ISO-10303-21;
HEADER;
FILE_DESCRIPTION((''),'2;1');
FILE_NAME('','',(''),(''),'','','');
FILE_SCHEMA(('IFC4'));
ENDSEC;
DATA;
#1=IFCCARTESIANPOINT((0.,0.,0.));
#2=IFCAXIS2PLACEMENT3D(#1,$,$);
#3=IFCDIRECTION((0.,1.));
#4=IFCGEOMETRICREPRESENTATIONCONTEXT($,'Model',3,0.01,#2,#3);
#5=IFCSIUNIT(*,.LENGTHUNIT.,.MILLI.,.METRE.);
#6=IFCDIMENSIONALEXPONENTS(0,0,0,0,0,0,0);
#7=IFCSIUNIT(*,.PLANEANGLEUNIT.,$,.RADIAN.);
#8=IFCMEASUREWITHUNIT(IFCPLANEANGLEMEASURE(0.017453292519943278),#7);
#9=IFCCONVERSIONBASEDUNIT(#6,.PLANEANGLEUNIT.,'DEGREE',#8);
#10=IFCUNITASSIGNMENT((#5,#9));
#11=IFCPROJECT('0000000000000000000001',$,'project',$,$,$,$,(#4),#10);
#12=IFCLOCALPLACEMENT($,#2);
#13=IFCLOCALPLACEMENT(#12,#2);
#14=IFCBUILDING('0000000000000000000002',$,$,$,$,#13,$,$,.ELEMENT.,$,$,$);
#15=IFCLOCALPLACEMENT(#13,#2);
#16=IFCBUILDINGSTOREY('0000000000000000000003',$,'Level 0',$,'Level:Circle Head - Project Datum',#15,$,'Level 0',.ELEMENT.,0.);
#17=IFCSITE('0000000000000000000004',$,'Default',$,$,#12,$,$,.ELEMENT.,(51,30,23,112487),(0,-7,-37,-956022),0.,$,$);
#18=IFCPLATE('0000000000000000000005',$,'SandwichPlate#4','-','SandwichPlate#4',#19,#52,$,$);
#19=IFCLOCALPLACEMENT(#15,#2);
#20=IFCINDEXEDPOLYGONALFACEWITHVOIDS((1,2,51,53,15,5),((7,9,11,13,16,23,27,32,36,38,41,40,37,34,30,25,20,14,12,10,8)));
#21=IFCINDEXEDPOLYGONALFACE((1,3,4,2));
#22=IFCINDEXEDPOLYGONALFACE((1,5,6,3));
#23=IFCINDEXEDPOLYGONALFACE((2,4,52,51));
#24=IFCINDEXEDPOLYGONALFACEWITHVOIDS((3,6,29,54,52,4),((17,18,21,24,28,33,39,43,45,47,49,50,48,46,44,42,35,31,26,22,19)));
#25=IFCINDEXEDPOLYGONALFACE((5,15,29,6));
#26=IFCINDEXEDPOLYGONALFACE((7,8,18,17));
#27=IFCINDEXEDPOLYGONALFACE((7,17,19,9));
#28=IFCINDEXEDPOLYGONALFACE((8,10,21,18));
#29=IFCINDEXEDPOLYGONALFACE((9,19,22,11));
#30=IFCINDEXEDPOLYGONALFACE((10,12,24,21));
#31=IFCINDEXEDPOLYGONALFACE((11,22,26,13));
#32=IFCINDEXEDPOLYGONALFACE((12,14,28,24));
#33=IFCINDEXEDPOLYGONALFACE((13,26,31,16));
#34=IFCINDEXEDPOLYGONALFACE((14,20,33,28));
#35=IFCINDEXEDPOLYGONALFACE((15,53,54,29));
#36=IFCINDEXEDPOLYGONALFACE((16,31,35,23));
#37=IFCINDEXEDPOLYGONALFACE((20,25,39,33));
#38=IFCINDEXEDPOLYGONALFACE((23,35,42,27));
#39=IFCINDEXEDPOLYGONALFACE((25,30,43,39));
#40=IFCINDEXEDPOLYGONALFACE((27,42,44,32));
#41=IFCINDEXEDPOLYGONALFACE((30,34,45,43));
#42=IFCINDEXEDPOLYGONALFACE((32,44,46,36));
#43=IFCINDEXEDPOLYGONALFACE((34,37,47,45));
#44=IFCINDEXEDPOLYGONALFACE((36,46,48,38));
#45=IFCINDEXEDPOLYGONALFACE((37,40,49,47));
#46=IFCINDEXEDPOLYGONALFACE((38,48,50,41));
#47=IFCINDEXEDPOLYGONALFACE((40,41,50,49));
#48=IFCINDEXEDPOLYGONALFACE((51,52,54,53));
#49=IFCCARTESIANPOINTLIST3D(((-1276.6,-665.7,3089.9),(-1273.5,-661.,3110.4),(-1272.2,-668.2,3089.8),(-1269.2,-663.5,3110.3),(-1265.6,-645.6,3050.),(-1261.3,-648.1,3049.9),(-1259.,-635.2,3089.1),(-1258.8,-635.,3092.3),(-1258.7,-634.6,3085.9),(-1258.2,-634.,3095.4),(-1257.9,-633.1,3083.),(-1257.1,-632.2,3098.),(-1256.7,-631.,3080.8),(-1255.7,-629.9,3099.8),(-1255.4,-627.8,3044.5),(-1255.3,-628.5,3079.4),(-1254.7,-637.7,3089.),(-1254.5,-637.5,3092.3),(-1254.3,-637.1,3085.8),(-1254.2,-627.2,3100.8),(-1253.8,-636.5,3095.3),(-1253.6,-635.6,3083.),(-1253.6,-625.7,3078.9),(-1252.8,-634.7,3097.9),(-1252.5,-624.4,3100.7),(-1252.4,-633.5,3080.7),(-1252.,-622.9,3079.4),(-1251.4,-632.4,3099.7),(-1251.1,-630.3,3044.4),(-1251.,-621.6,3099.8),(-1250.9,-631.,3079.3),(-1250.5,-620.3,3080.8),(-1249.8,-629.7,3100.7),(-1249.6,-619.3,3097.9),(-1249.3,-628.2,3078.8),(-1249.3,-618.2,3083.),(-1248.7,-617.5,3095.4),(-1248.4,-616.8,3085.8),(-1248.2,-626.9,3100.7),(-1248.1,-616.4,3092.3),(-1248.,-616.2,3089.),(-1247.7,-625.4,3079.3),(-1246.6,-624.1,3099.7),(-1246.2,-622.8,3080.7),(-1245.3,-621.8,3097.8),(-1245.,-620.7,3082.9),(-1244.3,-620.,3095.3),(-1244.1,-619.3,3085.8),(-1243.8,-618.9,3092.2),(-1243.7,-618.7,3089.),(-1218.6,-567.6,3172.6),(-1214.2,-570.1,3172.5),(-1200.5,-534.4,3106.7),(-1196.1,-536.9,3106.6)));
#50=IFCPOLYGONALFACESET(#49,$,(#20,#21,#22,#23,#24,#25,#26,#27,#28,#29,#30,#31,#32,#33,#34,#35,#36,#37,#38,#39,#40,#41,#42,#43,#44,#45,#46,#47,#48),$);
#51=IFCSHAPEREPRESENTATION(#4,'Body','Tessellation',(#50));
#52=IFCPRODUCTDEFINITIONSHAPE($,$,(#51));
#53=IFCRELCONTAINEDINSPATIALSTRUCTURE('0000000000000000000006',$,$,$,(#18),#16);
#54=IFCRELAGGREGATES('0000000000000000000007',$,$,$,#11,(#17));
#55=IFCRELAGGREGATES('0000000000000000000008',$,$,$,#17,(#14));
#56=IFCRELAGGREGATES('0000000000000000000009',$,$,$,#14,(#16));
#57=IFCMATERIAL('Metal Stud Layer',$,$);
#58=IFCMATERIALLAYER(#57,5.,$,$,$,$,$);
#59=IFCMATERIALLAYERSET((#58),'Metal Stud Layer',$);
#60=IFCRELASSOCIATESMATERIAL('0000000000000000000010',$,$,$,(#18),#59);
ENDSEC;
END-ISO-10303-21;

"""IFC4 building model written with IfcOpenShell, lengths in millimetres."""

from ifc_helpers import new_model, entity, si_unit, converted_unit, direction, frame, origin, origin_with_axes, origin_2d_with_axis, place, context, project, spatial, polyline, circle, outline, extrude, material, layer, layer_set, element, save


model = new_model("IFC4")

# Units and contexts
model_context = context("Model", 3, precision=0.01, world=origin(), true_north=direction((0.0, 1.0)))
ifc_project = project(units=[si_unit("LENGTHUNIT", "METRE", prefix="MILLI"), converted_unit("PLANEANGLEUNIT", "DEGREE", entity("IfcPlaneAngleMeasure", 0.017453292519943278), si_unit("PLANEANGLEUNIT", "RADIAN"), dimensions=[0, 0, 0, 0, 0, 0, 0])], contexts=[model_context])

# Site, building, storey
site_placement = place(None, origin())
site = spatial("IfcSite", under=ifc_project, at=site_placement, Name="Default", CompositionType="ELEMENT", RefLatitude=(51, 30, 23, 112487), RefLongitude=(0, -7, -37, -956022), RefElevation=0.0)
building_placement = place(site_placement, origin())
building = spatial("IfcBuilding", under=site, at=building_placement, CompositionType="ELEMENT")
storey_placement = place(building_placement, origin())
storey = spatial("IfcBuildingStorey", under=building, at=storey_placement, Name="Level 0", ObjectType="Level:Circle Head - Project Datum", LongName="Level 0", CompositionType="ELEMENT", Elevation=0.0)

# Plate, openings
ifc_material = material(Name="Metal Stud Layer")
ifc_layer_1 = layer(ifc_material, 5.0)
ifc_layer_set_1 = layer_set([ifc_layer_1], Name="Metal Stud Layer")
plate_1_placement = place(storey_placement, frame((-1257.7, -641.5, 3036.9), z_axis=(-0.865935, 0.499948, 0.014432), x_axis=(-0.238139, -0.437501, 0.867112)))
plate_1 = element("IfcPlate", 1, at=plate_1_placement, inside=storey, material=ifc_layer_set_1, Name="SandwichPlate#4", Description="-", ObjectType="SandwichPlate#4", context=model_context, shape_type="SweptSolid", body=[
    extrude(outline(polyline([(0.0, 0.0), (76.0, 0.0), (76.0, 140.0), (0.0, 140.0), (0.0, 0.0)])), origin_with_axes(), (0.0, 0.0, 1.0), 5.0),
])
opening_1_placement = place(plate_1_placement, frame((0.0, 0.0, 0.0), z_axis=(0.0, 0.0, 1.0), x_axis=(1.0, 0.0, 0.0)))
element("IfcOpeningElement", 2, at=opening_1_placement, cuts=plate_1, ObjectType="Opening", context=model_context, shape_type="SweptSolid", body=[
    extrude(outline(polyline([(0.0, 0.0), (15.0, 0.0), (0.0, 15.0), (0.0, 0.0)])), origin(), (0.0, 0.0, 1.0), 5.0),
])
opening_2_placement = place(plate_1_placement, frame((0.0, 0.0, 0.0), z_axis=(0.0, 0.0, 1.0), x_axis=(1.0, 0.0, 0.0)))
element("IfcOpeningElement", 3, at=opening_2_placement, cuts=plate_1, ObjectType="Opening", context=model_context, shape_type="SweptSolid", body=[
    extrude(outline(polyline([(76.0, 0.0), (76.0, 15.0), (61.0, 0.0), (76.0, 0.0)])), origin(), (0.0, 0.0, 1.0), 5.0),
])
opening_3_placement = place(plate_1_placement, frame((38.0, 40.0, -0.5), z_axis=(0.0, 0.0, 1.0), x_axis=(0.0, 1.0, 0.0)))
element("IfcOpeningElement", 4, at=opening_3_placement, cuts=plate_1, ObjectType="Opening", context=model_context, shape_type="SweptSolid", body=[
    extrude(circle(Radius=11.0, at=origin_2d_with_axis()), origin(), (0.0, 0.0, 1.0), 6.0),
])

save(model, "model.ifc")
